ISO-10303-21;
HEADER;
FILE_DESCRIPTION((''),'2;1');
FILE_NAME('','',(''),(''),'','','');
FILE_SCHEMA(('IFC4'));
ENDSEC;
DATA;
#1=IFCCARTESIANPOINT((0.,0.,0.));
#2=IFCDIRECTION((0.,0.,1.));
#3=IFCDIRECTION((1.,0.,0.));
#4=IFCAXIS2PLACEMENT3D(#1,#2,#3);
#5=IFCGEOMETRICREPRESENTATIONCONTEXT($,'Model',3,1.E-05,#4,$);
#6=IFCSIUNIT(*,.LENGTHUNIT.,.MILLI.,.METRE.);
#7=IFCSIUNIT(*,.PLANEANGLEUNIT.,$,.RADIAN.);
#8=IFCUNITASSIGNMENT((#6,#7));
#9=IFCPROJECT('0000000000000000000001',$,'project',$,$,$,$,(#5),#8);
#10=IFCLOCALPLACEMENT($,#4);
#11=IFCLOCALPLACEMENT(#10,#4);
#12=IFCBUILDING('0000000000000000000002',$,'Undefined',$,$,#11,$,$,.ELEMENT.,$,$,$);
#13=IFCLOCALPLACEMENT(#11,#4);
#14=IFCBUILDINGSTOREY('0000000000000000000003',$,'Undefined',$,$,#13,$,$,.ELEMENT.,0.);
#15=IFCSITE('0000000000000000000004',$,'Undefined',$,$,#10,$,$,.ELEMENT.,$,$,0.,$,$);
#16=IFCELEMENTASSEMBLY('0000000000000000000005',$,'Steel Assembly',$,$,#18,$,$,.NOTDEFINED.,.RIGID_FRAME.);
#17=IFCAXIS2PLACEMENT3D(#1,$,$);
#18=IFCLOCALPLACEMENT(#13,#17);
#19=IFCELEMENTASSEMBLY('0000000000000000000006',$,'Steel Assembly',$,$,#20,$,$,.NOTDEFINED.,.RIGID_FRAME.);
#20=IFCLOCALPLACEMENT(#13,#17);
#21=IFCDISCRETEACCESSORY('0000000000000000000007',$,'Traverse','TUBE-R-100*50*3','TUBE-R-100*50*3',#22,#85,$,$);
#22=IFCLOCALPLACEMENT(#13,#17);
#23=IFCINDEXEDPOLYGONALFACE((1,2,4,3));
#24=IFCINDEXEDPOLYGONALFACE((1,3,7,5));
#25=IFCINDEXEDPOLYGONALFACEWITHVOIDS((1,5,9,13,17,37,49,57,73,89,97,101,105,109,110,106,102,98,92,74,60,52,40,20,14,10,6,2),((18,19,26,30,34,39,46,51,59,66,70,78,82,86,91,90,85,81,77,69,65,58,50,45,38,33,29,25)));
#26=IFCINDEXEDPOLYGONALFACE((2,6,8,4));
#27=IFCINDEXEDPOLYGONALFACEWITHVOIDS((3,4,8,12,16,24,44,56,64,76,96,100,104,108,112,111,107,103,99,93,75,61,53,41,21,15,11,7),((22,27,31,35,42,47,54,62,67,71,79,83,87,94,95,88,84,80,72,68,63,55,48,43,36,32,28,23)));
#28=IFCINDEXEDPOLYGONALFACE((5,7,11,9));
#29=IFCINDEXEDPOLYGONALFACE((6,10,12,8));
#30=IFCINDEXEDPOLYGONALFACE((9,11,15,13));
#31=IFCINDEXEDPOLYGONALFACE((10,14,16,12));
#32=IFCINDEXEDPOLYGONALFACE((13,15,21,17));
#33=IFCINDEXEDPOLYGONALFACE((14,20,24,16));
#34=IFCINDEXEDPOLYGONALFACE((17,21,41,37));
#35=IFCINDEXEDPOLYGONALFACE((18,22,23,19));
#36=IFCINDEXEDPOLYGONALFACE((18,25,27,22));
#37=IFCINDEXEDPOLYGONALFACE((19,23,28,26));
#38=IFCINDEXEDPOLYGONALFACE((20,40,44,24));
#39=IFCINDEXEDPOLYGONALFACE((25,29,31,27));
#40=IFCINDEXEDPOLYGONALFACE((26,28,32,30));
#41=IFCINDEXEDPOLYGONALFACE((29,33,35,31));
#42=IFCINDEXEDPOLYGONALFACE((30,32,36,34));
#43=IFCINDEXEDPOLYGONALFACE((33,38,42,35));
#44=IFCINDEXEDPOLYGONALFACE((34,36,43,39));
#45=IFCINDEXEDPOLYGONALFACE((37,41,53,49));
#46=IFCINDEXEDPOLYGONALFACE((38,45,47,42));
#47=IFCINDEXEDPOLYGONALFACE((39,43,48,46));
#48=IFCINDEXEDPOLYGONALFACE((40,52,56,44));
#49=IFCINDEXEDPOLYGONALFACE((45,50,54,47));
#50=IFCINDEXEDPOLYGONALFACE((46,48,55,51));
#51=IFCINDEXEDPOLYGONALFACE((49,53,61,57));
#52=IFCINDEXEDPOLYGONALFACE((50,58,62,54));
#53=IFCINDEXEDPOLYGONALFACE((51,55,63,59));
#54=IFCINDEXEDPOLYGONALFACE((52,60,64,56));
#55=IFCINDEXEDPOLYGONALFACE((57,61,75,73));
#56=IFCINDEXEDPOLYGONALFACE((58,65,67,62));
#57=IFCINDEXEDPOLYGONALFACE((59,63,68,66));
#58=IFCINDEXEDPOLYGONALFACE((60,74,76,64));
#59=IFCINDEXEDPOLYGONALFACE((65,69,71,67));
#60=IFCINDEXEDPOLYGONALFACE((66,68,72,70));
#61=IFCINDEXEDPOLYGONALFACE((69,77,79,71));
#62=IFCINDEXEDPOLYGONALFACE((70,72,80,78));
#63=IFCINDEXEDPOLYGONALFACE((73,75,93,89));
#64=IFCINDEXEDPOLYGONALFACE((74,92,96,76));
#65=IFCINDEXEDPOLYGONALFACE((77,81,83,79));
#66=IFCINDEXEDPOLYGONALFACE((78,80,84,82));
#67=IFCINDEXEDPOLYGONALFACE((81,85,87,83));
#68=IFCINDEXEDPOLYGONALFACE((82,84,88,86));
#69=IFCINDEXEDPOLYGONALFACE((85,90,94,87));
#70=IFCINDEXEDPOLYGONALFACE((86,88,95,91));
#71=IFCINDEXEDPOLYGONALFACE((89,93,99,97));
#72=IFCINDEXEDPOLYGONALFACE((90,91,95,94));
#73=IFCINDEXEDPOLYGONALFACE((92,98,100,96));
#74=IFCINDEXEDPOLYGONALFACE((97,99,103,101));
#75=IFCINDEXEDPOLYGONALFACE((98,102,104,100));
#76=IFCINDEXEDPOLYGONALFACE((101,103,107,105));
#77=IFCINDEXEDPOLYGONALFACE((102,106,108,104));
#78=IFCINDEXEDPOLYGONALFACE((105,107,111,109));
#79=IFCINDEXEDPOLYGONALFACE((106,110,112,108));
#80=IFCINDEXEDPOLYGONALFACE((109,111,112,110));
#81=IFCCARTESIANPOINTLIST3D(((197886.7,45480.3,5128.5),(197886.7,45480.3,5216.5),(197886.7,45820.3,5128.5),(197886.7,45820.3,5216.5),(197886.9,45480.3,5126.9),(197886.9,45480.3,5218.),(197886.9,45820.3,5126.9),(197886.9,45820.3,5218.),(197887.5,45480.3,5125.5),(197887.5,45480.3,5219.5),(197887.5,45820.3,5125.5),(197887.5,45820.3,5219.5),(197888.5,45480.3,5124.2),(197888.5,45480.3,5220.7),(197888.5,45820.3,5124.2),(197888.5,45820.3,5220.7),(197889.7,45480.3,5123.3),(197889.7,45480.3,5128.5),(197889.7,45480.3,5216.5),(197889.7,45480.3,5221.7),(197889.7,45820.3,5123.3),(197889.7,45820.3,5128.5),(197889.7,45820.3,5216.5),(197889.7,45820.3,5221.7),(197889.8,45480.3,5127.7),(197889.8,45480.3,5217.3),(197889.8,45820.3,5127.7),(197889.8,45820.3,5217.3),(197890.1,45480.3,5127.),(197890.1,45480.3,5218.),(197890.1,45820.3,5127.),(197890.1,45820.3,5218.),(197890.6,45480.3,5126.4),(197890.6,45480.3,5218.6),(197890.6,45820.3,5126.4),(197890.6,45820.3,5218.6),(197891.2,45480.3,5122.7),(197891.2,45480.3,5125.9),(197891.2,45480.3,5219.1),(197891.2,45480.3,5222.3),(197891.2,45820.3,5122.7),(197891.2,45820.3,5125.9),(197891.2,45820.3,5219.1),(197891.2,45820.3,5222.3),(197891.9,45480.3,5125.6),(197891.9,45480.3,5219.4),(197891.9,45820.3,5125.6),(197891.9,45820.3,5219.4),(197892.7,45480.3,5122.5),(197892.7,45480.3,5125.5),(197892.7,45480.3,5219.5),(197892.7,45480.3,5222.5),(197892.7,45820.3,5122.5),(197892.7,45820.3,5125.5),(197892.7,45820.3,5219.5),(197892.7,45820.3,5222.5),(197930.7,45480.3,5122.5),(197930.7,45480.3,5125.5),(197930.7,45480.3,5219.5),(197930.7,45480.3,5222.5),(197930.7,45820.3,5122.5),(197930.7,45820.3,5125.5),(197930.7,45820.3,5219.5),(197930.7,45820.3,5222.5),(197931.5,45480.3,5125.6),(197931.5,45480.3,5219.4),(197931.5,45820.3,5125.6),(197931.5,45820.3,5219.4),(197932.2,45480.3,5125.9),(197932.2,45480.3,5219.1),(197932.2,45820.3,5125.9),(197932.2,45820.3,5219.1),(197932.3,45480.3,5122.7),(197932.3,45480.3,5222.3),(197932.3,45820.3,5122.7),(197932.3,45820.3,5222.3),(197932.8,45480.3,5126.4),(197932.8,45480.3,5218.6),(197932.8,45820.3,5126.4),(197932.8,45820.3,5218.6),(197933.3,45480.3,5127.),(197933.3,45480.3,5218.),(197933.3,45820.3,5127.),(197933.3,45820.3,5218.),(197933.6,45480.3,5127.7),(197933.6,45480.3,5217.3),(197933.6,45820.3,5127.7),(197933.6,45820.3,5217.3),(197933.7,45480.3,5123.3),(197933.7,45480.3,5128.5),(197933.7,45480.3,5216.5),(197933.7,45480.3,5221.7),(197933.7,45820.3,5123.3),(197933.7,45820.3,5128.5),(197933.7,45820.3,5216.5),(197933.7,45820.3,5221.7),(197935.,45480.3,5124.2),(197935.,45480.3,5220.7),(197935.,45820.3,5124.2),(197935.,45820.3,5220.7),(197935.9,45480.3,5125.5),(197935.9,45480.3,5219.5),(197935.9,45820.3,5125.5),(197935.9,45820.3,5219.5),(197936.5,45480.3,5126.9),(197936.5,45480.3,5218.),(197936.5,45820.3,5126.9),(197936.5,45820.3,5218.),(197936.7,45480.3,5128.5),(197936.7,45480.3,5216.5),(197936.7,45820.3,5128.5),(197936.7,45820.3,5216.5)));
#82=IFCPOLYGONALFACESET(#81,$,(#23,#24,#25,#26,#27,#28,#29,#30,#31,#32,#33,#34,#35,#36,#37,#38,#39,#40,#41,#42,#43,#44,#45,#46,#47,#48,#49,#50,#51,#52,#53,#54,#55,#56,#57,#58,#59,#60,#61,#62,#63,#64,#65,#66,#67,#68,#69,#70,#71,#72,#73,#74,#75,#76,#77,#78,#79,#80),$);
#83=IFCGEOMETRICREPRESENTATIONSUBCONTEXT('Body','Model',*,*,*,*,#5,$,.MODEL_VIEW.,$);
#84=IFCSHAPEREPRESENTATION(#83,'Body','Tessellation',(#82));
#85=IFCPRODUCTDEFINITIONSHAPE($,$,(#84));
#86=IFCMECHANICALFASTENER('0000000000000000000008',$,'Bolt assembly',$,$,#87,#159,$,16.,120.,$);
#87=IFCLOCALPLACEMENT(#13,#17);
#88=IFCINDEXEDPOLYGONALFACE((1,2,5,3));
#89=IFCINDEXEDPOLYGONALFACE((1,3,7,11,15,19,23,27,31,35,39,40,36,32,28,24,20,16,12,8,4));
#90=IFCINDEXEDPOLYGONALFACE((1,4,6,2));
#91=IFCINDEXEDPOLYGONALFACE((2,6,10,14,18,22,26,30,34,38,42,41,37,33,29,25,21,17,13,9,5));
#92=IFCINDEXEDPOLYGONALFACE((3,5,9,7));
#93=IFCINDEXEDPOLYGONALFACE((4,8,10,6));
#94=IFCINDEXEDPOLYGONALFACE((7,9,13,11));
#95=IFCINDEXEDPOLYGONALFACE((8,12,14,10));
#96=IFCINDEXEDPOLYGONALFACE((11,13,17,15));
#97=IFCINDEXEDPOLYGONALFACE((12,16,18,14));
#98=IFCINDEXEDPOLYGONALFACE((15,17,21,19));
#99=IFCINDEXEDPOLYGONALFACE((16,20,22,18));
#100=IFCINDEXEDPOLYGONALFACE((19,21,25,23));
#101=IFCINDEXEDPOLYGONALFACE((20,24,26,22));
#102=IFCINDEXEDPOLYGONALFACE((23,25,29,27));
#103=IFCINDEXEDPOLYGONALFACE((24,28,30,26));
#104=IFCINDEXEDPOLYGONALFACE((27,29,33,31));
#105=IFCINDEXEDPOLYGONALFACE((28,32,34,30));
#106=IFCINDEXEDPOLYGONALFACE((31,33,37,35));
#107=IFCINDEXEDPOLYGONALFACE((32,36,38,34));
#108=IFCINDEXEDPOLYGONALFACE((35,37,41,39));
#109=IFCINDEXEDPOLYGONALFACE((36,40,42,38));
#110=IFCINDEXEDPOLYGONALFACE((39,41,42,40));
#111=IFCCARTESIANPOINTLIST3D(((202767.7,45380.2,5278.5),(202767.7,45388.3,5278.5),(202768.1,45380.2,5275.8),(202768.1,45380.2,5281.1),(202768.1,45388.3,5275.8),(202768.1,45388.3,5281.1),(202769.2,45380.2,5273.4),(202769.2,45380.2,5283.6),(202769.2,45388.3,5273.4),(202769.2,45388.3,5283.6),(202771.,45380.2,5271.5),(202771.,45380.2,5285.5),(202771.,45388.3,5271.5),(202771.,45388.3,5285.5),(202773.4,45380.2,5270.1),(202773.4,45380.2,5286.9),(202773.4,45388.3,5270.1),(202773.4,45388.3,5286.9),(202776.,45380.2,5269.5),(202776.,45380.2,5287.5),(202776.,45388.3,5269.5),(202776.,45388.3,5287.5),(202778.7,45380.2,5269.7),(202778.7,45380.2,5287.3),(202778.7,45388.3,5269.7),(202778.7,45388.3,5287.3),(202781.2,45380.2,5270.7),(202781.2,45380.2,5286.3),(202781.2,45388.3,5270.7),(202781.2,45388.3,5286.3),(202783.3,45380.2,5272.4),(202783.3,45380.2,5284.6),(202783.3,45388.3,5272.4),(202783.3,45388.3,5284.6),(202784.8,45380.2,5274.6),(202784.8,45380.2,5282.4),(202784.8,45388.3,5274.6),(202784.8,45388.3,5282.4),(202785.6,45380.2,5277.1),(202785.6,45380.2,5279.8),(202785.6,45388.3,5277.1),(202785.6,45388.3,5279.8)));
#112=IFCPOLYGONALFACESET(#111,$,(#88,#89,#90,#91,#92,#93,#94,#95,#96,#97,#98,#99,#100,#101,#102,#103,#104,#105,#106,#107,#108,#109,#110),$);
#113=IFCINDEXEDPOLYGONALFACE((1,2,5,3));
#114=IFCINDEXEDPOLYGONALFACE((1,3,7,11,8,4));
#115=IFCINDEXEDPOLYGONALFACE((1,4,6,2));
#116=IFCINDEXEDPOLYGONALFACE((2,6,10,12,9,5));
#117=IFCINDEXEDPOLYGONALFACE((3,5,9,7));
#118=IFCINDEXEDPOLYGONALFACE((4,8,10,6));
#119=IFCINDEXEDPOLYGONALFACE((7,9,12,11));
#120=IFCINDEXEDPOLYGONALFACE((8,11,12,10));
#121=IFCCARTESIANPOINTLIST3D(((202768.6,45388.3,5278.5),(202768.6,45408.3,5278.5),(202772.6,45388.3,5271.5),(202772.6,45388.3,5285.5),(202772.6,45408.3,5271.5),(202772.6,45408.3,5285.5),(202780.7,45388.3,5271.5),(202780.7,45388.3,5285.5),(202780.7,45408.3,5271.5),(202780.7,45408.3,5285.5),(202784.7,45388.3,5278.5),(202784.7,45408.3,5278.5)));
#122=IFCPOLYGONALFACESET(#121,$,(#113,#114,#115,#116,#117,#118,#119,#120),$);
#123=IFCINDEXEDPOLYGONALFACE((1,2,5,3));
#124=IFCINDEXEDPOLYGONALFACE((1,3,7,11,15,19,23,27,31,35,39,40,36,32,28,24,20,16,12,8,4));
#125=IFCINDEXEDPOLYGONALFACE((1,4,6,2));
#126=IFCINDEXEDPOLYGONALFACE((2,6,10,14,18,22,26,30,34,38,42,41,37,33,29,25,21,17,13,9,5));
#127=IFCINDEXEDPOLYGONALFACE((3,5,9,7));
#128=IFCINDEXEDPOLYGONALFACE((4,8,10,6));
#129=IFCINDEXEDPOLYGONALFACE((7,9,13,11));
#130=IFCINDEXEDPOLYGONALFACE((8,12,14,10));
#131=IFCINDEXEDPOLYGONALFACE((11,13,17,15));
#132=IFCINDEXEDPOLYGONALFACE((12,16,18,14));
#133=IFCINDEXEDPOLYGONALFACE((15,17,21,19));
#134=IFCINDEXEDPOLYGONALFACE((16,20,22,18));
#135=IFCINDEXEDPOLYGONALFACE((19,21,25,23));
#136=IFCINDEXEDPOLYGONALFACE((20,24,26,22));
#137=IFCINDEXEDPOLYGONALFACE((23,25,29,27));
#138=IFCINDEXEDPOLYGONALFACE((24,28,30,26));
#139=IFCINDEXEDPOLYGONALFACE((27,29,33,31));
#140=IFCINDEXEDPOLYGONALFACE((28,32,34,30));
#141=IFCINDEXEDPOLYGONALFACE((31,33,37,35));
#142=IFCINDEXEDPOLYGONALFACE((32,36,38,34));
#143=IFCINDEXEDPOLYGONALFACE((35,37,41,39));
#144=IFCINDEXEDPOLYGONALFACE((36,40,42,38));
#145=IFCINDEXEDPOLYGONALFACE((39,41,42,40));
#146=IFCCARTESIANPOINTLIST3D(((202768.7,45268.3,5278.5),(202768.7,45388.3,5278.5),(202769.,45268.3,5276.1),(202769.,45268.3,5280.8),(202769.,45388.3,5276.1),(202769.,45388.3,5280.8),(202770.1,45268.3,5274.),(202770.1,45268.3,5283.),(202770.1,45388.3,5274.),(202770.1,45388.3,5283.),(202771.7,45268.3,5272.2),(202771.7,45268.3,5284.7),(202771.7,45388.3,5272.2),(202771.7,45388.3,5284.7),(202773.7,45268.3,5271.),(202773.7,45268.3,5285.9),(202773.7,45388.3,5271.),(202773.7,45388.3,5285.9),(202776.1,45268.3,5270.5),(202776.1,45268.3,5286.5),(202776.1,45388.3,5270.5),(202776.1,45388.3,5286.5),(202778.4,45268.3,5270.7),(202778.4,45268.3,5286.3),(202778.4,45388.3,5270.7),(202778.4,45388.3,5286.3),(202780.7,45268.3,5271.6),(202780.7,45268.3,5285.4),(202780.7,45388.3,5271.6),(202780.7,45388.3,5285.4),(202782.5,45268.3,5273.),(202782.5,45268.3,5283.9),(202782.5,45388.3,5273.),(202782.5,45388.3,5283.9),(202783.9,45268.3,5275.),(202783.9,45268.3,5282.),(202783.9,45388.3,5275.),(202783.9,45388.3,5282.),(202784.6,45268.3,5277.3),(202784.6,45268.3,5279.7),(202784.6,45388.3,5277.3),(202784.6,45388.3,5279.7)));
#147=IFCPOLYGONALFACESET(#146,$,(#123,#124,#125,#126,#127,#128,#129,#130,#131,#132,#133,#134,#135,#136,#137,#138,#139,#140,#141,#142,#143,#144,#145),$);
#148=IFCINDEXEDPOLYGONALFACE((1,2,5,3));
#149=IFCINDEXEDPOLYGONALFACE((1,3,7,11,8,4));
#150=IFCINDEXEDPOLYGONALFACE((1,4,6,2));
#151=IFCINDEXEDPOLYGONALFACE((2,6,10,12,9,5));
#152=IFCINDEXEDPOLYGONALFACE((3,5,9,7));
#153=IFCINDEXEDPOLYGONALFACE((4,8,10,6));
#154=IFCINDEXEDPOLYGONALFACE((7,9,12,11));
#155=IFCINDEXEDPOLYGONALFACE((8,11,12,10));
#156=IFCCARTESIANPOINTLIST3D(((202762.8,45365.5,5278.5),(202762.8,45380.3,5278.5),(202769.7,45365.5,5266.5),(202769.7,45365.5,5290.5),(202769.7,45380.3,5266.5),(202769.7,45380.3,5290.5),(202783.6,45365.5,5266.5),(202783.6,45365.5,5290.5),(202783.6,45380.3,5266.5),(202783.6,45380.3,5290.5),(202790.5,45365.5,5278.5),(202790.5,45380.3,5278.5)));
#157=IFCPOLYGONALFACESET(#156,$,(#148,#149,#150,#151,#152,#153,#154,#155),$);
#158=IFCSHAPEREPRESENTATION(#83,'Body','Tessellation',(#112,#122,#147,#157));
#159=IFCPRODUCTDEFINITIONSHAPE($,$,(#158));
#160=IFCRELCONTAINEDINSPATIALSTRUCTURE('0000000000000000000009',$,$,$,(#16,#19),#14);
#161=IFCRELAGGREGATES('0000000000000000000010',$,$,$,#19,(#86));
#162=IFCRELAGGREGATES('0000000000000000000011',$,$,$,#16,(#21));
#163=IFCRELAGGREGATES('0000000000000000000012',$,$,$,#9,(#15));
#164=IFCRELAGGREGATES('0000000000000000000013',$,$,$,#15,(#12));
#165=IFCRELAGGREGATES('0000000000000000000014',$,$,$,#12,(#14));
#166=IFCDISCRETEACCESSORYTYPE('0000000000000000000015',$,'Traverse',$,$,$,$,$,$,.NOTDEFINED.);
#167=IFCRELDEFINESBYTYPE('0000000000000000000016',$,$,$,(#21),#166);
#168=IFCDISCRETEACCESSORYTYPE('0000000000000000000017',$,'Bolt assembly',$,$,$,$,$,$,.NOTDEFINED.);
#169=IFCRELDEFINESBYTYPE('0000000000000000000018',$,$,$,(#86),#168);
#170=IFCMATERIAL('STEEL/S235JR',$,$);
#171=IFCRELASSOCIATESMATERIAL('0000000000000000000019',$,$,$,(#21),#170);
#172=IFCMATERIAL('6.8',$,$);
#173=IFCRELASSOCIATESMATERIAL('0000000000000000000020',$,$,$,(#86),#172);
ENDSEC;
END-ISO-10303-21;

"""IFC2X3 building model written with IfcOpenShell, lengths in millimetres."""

from ifc_helpers import new_model, si_unit, frame, origin_with_axes, origin_2d_with_axis, place, context, subcontext, project, spatial, polyline, hollow_rectangle, circle, outline, extrude, source, transform, mapped, material, type_object, element, aggregate, save


model = new_model("IFC2X3")

# Units and contexts
model_context = context("Model", 3, precision=1e-05, world=origin_with_axes())
body_context = subcontext(model_context, "Body", "Model", "MODEL_VIEW")
ifc_project = project(units=[si_unit("LENGTHUNIT", "METRE", prefix="MILLI"), si_unit("PLANEANGLEUNIT", "RADIAN")], contexts=[model_context])

# Site, building, storey
site_placement = place(None, origin_with_axes())
site = spatial("IfcSite", under=ifc_project, at=site_placement, Name="Undefined", CompositionType="ELEMENT", RefElevation=0.0)
building_placement = place(site_placement, origin_with_axes())
building = spatial("IfcBuilding", under=site, at=building_placement, Name="Undefined", CompositionType="ELEMENT")
storey_placement = place(building_placement, origin_with_axes())
storey = spatial("IfcBuildingStorey", under=building, at=storey_placement, Name="Undefined", CompositionType="ELEMENT", Elevation=0.0)

# Shared definitions
ifc_material_1 = material(Name="STEEL/S235JR")

# Shared definitions
discrete_accessory_type_1 = type_object("IfcDiscreteAccessoryType", Name="Bolt assembly")

# Element assembly
assembly_1_placement = place(storey_placement, origin_with_axes())
assembly_1 = element("IfcElementAssembly", 1, at=assembly_1_placement, inside=storey, Name="Steel Assembly", AssemblyPlace="NOTDEFINED", PredefinedType="RIGID_FRAME")

# Element assembly
assembly_2_placement = place(storey_placement, origin_with_axes())
assembly_2 = element("IfcElementAssembly", 2, at=assembly_2_placement, inside=storey, Name="Steel Assembly", AssemblyPlace="NOTDEFINED", PredefinedType="RIGID_FRAME")

# Discrete accessory
discrete_accessory_type_2 = type_object("IfcDiscreteAccessoryType", Name="Traverse")
discrete_accessory_1_placement = place(assembly_1_placement, frame((197911.7, 45480.3, 5172.5), z_axis=(0.0, 0.0, 1.0), x_axis=(0.0, 1.0, 0.0)))
discrete_accessory_1 = element("IfcDiscreteAccessory", 3, at=discrete_accessory_1_placement, type_object=discrete_accessory_type_2, material=ifc_material_1, Name="Traverse", Description="TUBE-R-100*50*3", ObjectType="TUBE-R-100*50*3", context=body_context, shape_type="SweptSolid", body=[
    extrude(hollow_rectangle(XDim=50.0, YDim=100.0, WallThickness=3.0, InnerFilletRadius=3.0, OuterFilletRadius=6.0, at=origin_2d_with_axis()), frame((340.0, 0.0, 0.0), z_axis=(-1.0, 0.0, 0.0), x_axis=(0.0, -1.0, 0.0)), (0.0, 0.0, 1.0), 340.0),
])

# Mechanical fastener
ifc_material_2 = material(Name="6.8")
shared_shape_1 = source(origin_with_axes(), body_context, "Body", "SweptSolid", [
    extrude(circle(Radius=9.0, at=origin_2d_with_axis()), frame((0.0, -8.0, 0.0), z_axis=(0.0, 1.0, 0.0), x_axis=(1.0, 0.0, 0.0)), (0.0, 0.0, 1.0), 8.1),
    extrude(outline(polyline([(8.1, 0.0), (4.0, 7.0), (-4.0, 7.0), (-8.1, 0.0), (-4.0, -7.0), (4.0, -7.0), (8.1, 0.0)])), frame((0.0, -28.0, 0.0), z_axis=(0.0, 1.0, 0.0), x_axis=(1.0, 0.0, 0.0)), (0.0, 0.0, 1.0), 20.0),
    extrude(circle(Radius=8.0, at=origin_2d_with_axis()), frame((0.0, -8.0, 0.0), z_axis=(0.0, 1.0, 0.0), x_axis=(1.0, 0.0, 0.0)), (0.0, 0.0, 1.0), 120.0),
    extrude(outline(polyline([(13.9, 0.0), (6.9, 12.0), (-6.9, 12.0), (-13.9, 0.0), (-6.9, -12.0), (6.9, -12.0), (13.9, 0.0)])), frame((0.0, 0.0, 0.0), z_axis=(0.0, 1.0, 0.0), x_axis=(1.0, 0.0, 0.0)), (0.0, 0.0, 1.0), 14.8),
])
mechanical_fastener_1_placement = place(assembly_2_placement, frame((202776.7, 45380.3, 5278.5), z_axis=(0.0, 0.0, 1.0), x_axis=(-1.0, 0.0, 0.0)))
mechanical_fastener_1 = element("IfcMechanicalFastener", 4, at=mechanical_fastener_1_placement, type_object=discrete_accessory_type_1, material=ifc_material_2, Name="Bolt assembly", NominalDiameter=16.0, NominalLength=120.0, context=body_context, shape_type="MappedRepresentation", body=[
    mapped(shared_shape_1, transform((0.0, 0.0, 0.0))),
])

aggregate(assembly_2, [mechanical_fastener_1])
aggregate(assembly_1, [discrete_accessory_1])

save(model, "model.ifc")
